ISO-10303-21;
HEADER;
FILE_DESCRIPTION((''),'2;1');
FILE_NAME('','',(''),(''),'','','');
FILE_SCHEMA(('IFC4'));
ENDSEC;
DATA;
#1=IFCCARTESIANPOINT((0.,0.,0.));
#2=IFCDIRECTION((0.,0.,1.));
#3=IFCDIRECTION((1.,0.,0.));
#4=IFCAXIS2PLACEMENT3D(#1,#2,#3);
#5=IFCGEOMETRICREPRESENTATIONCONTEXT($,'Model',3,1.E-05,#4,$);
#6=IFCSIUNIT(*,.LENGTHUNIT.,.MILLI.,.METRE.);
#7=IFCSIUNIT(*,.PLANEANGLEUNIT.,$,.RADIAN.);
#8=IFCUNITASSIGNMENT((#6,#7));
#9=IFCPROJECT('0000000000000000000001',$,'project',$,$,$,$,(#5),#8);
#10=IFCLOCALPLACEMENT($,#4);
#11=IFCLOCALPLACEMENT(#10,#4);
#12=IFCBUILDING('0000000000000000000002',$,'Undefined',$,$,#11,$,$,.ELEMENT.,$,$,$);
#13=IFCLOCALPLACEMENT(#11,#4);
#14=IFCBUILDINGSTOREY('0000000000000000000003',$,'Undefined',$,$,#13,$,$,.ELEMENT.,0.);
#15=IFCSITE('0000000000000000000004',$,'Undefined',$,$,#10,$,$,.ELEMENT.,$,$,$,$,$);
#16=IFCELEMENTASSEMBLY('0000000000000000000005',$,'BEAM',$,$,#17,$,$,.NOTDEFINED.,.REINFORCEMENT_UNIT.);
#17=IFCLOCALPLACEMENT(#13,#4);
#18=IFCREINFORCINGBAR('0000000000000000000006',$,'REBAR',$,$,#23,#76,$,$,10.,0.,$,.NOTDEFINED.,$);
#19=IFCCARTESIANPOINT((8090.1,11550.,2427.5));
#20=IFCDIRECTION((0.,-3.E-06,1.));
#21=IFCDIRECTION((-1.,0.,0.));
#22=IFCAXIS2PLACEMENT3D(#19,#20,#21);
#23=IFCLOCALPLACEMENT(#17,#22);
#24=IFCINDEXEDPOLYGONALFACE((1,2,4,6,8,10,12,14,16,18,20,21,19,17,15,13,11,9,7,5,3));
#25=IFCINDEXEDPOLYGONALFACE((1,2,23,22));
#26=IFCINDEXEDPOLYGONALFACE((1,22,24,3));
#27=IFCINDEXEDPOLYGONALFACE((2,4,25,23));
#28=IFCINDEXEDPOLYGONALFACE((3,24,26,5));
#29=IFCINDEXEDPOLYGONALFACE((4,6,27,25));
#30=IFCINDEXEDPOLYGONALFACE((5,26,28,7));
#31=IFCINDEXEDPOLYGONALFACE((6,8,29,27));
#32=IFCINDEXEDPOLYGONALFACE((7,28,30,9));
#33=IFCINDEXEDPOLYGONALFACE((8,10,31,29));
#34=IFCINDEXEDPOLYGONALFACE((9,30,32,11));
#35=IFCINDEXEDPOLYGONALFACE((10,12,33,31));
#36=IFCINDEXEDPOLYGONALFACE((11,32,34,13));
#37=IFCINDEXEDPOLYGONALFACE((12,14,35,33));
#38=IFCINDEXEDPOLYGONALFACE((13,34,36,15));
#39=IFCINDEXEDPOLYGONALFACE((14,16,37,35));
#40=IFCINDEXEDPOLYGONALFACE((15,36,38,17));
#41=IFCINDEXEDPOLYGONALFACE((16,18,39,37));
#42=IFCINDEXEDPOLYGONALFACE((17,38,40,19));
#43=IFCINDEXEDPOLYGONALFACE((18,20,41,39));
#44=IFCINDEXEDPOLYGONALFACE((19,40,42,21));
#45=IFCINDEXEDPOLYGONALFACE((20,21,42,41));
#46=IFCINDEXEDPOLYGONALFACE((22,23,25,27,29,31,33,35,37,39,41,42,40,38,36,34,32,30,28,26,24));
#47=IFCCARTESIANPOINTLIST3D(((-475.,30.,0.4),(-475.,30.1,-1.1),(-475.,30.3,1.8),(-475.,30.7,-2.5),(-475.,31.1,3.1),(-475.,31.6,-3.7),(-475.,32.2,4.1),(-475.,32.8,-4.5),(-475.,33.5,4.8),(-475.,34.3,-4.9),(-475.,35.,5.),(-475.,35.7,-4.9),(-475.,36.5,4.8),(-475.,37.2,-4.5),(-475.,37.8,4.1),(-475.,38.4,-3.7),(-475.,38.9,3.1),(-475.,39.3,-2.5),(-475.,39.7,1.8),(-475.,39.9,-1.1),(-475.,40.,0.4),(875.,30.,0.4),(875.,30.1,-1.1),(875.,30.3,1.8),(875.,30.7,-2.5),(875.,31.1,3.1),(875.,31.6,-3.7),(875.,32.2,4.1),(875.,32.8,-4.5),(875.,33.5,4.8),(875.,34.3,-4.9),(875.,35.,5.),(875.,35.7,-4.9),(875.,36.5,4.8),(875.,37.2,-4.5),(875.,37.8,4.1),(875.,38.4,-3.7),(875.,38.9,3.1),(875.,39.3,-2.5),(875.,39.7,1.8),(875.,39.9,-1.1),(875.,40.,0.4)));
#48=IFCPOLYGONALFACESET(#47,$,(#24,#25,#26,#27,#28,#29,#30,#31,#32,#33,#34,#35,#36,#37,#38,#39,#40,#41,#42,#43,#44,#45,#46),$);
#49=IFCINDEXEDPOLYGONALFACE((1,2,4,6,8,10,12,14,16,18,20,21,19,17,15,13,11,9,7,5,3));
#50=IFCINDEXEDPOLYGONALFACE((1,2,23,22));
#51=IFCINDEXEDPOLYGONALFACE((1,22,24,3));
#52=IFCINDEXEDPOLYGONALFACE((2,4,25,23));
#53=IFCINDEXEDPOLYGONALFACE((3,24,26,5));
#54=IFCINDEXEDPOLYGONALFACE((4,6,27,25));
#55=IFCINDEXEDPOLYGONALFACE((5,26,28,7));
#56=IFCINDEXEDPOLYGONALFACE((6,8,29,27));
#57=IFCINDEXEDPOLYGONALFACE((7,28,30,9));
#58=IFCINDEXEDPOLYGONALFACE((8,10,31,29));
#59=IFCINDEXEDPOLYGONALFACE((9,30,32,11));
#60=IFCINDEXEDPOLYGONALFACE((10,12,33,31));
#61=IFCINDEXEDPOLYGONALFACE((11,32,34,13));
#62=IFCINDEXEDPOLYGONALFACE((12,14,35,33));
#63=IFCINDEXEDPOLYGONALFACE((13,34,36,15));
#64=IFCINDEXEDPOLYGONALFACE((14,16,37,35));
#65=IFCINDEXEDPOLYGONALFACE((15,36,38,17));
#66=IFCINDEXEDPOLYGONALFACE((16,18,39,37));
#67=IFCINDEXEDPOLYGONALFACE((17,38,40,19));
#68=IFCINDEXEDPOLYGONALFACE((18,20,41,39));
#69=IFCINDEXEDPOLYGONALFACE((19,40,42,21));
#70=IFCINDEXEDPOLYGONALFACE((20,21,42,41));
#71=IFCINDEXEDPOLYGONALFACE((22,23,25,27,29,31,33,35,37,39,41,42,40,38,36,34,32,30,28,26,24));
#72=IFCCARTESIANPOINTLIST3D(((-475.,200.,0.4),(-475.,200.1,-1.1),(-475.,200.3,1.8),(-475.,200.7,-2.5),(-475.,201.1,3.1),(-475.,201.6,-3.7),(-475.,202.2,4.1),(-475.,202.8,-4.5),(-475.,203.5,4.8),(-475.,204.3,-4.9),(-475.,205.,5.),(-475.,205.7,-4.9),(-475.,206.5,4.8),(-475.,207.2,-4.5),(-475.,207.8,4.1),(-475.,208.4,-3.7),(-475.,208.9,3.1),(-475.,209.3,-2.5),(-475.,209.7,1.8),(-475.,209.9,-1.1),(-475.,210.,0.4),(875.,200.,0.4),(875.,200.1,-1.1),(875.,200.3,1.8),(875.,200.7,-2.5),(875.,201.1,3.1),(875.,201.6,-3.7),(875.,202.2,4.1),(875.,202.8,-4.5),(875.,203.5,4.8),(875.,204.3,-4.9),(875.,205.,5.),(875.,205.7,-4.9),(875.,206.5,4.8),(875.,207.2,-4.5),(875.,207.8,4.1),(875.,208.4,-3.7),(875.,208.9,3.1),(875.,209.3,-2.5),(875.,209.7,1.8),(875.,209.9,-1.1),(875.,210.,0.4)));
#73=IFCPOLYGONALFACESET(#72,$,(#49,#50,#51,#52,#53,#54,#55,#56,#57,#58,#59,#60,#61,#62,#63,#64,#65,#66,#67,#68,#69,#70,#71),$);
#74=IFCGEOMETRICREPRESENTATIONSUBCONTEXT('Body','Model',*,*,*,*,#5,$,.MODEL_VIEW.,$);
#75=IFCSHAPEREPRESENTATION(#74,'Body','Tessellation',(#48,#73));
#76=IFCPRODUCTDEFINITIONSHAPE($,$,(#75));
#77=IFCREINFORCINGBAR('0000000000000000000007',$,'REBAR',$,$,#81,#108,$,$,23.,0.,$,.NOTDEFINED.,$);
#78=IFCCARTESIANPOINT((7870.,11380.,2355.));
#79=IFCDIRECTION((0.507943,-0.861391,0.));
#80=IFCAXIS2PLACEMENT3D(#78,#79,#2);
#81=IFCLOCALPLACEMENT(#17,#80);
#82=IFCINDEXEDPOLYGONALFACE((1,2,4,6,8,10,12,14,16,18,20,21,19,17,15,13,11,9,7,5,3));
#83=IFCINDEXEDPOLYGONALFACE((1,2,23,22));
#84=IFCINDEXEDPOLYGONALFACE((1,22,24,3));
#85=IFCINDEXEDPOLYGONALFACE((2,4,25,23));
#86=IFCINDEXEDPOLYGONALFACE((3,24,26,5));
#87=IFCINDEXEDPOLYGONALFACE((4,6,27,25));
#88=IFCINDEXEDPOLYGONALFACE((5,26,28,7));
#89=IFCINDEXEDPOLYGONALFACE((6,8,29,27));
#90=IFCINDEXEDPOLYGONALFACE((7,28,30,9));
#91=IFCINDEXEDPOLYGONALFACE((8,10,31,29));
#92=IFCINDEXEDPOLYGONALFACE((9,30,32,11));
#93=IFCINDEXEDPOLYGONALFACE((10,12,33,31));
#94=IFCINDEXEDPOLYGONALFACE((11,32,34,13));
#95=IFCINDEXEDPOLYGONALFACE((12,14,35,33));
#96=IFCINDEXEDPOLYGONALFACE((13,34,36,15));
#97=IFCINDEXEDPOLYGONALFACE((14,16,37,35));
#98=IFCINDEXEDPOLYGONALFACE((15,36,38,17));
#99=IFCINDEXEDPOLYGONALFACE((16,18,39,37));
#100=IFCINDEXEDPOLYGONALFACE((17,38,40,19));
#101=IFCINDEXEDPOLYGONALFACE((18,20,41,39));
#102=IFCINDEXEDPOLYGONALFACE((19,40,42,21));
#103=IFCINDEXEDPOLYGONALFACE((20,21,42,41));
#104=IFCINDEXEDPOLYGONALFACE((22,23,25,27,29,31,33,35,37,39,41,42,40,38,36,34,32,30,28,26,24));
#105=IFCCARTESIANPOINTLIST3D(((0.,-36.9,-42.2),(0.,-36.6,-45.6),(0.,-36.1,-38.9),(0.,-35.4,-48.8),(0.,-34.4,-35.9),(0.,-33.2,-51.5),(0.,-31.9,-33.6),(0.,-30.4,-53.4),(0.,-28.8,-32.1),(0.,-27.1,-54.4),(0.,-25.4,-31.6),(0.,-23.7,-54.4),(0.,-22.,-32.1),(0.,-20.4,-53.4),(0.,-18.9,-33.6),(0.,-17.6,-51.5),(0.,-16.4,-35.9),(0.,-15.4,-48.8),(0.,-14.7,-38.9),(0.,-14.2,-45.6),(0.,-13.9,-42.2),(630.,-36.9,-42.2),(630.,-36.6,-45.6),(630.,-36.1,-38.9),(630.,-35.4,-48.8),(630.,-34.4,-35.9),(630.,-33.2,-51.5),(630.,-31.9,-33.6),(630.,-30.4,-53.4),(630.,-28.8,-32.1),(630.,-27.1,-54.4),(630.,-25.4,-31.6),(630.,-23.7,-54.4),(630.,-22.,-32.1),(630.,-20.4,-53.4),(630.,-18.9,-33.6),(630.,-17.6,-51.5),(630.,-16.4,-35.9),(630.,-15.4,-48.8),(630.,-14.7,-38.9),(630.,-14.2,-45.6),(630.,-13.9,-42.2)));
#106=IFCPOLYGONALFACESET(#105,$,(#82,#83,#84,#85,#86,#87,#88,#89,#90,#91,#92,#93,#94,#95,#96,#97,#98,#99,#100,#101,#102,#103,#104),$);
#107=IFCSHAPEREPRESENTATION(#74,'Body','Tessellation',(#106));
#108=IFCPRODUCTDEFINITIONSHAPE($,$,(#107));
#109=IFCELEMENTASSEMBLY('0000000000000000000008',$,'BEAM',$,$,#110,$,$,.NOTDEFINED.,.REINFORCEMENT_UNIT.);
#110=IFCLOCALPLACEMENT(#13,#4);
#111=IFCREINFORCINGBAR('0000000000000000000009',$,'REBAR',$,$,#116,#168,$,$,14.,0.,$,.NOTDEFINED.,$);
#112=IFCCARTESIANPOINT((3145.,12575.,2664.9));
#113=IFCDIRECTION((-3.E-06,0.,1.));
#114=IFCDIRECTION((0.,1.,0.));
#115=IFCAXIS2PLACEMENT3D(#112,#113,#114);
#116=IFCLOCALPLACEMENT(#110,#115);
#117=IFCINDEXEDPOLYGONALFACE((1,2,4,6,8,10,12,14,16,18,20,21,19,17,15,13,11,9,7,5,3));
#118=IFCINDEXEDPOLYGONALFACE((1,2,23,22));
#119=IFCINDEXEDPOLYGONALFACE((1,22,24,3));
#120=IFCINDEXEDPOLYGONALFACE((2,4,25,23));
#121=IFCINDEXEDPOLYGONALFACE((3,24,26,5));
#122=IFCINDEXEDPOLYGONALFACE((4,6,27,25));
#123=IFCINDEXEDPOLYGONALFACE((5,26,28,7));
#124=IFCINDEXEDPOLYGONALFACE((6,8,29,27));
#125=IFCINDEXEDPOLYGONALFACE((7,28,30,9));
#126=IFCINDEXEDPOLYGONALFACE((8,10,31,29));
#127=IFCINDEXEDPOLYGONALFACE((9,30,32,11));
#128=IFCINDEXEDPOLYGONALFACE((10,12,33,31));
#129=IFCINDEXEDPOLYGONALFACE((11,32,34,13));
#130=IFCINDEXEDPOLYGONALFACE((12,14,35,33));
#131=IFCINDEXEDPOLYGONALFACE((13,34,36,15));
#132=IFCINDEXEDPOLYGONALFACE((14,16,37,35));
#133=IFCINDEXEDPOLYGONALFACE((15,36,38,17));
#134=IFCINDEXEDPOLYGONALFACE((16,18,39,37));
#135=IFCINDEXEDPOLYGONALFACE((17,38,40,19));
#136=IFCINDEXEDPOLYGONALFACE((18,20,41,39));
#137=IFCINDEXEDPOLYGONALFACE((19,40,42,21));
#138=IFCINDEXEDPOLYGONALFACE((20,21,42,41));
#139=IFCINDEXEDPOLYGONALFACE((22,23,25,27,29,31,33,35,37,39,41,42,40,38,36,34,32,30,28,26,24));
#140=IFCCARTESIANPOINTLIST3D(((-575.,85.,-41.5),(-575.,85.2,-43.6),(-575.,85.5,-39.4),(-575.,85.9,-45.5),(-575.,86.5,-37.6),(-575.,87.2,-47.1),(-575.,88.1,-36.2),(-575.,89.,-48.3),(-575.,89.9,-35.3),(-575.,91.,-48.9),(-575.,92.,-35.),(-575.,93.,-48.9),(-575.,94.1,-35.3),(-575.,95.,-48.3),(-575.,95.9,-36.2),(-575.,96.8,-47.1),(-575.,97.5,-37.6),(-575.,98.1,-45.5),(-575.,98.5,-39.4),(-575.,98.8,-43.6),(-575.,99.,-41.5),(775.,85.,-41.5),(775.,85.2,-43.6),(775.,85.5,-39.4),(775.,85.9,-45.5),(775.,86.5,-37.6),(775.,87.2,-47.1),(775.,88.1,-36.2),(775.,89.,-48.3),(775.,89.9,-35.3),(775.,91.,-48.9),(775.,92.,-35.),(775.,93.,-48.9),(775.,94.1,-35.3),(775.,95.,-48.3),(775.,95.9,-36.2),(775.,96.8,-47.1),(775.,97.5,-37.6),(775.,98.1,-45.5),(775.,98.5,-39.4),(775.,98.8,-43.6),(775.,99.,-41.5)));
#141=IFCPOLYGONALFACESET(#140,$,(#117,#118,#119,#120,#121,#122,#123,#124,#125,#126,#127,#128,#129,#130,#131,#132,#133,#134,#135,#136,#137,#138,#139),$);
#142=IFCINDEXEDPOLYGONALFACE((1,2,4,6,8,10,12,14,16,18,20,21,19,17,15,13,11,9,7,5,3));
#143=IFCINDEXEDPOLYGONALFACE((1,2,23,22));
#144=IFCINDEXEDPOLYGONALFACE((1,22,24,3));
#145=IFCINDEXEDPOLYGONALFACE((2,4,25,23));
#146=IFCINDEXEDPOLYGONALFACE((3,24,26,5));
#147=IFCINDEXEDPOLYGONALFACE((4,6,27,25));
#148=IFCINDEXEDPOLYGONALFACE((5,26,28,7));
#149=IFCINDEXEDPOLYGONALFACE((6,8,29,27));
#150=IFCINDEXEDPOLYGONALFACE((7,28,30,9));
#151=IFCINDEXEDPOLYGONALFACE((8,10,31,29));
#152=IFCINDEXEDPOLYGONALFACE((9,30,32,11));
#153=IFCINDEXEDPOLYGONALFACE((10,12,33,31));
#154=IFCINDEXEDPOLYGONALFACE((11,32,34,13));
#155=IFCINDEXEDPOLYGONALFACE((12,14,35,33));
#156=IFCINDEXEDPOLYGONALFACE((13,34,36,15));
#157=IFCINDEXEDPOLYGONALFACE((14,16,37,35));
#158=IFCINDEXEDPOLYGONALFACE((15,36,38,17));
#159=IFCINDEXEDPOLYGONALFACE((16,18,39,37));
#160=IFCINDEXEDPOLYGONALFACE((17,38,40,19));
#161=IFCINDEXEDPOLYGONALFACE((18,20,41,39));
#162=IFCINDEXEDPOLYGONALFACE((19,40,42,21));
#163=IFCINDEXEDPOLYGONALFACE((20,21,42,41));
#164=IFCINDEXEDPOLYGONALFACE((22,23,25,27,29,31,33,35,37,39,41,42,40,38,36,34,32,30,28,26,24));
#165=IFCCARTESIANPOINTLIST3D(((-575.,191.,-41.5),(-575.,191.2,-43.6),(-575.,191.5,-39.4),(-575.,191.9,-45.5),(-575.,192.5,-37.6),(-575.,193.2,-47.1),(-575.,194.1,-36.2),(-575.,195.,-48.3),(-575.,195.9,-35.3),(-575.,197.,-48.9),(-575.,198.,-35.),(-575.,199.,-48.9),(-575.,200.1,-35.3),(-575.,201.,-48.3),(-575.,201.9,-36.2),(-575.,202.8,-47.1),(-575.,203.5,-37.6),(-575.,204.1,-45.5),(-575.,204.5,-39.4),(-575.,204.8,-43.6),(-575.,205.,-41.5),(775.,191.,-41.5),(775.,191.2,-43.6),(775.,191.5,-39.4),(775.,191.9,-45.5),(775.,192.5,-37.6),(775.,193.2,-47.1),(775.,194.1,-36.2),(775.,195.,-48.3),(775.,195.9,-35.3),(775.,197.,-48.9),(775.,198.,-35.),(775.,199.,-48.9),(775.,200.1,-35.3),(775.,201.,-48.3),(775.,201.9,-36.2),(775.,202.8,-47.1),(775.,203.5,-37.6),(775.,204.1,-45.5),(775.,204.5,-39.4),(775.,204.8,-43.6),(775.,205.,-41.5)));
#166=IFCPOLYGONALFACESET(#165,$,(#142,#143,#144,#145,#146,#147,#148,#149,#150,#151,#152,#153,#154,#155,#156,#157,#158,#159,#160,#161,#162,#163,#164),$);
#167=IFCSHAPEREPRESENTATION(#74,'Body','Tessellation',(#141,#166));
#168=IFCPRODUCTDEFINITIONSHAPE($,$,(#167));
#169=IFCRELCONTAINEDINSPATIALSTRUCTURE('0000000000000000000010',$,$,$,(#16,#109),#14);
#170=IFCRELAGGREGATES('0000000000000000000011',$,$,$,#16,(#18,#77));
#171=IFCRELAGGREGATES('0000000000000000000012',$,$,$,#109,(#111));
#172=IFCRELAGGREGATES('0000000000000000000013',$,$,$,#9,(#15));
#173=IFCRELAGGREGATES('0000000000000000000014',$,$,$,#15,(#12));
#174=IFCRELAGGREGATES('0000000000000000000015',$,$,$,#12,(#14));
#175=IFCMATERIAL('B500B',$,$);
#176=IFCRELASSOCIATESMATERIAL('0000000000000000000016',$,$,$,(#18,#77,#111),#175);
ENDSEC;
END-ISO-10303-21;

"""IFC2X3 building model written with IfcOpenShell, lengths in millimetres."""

from ifc_helpers import new_model, entity, si_unit, frame, origin_with_axes, place, context, subcontext, project, spatial, source, transform, mapped, material, element, aggregate, save


model = new_model("IFC2X3")

# Units and contexts
model_context = context("Model", 3, precision=1e-05, world=origin_with_axes())
body_context = subcontext(model_context, "Body", "Model", "MODEL_VIEW")
ifc_project = project(units=[si_unit("LENGTHUNIT", "METRE", prefix="MILLI"), si_unit("PLANEANGLEUNIT", "RADIAN")], contexts=[model_context])

# Site, building, storey
site_placement = place(None, origin_with_axes())
site = spatial("IfcSite", under=ifc_project, at=site_placement, Name="Undefined", CompositionType="ELEMENT")
building_placement = place(site_placement, origin_with_axes())
building = spatial("IfcBuilding", under=site, at=building_placement, Name="Undefined", CompositionType="ELEMENT")
storey_placement = place(building_placement, origin_with_axes())
storey = spatial("IfcBuildingStorey", under=building, at=storey_placement, Name="Undefined", CompositionType="ELEMENT", Elevation=0.0)

# Element assembly
assembly_1_placement = place(storey_placement, origin_with_axes())
assembly_1 = element("IfcElementAssembly", 1, at=assembly_1_placement, inside=storey, Name="BEAM", AssemblyPlace="NOTDEFINED", PredefinedType="REINFORCEMENT_UNIT")

# Shared definitions
ifc_material_1 = material(Name="B500B")

# Reinforcing bars
shared_shape_1 = source(origin_with_axes(), body_context, "Body", "AdvancedSweptSolid", [
    entity("IfcSweptDiskSolid", entity("IfcTrimmedCurve", entity("IfcLine", entity("IfcCartesianPoint", [0.0, 0.0, 0.0]), entity("IfcVector", entity("IfcDirection", [1.0, 0.0, 0.0]), 1.0)), [entity("IfcParameterValue", 0.0)], [entity("IfcParameterValue", 1349.999613)], True, "PARAMETER"), 5.0, None, 0.0, 1350.0),
])
shared_shape_2 = source(origin_with_axes(), body_context, "Body", "AdvancedSweptSolid", [
    entity("IfcSweptDiskSolid", entity("IfcTrimmedCurve", entity("IfcLine", entity("IfcCartesianPoint", [0.0, 0.0, 0.0]), entity("IfcVector", entity("IfcDirection", [1.0, 0.0, 0.0]), 1.0)), [entity("IfcParameterValue", 0.0)], [entity("IfcParameterValue", 1349.999613)], True, "PARAMETER"), 5.0, None, 0.0, 1350.0),
])
reinforcing_bar_1_placement = place(assembly_1_placement, frame((8090.1, 11550.0, 2427.5), z_axis=(0.0, -0.000003, 1.0), x_axis=(-1.0, 0.0, 0.0)))
reinforcing_bar_1 = element("IfcReinforcingBar", 2, at=reinforcing_bar_1_placement, material=ifc_material_1, Name="REBAR", BarRole="NOTDEFINED", CrossSectionArea=0.0, NominalDiameter=10.0, context=body_context, shape_type="MappedRepresentation", body=[
    mapped(shared_shape_1, transform((-475.0, 35.0, 0.0))),
    mapped(shared_shape_2, transform((-475.0, 205.0, 0.0))),
])
shared_shape_3 = source(origin_with_axes(), body_context, "Body", "AdvancedSweptSolid", [
    entity("IfcSweptDiskSolid", entity("IfcTrimmedCurve", entity("IfcLine", entity("IfcCartesianPoint", [0.0, 0.0, 0.0]), entity("IfcVector", entity("IfcDirection", [1.0, 0.0, 0.0]), 1.0)), [entity("IfcParameterValue", 0.0)], [entity("IfcParameterValue", 630.0)], True, "PARAMETER"), 11.5, None, 0.0, 630.0),
])
reinforcing_bar_2_placement = place(assembly_1_placement, frame((7870.0, 11380.0, 2355.0), z_axis=(0.507943, -0.861391, 0.0), x_axis=(0.0, 0.0, 1.0)))
reinforcing_bar_2 = element("IfcReinforcingBar", 3, at=reinforcing_bar_2_placement, material=ifc_material_1, Name="REBAR", BarRole="NOTDEFINED", CrossSectionArea=0.0, NominalDiameter=23.0, context=body_context, shape_type="MappedRepresentation", body=[
    mapped(shared_shape_3, transform((0.0, -25.4, -43.1))),
])
aggregate(assembly_1, [reinforcing_bar_1, reinforcing_bar_2])

# Element assembly, reinforcing bar
assembly_2_placement = place(storey_placement, origin_with_axes())
assembly_2 = element("IfcElementAssembly", 4, at=assembly_2_placement, inside=storey, Name="BEAM", AssemblyPlace="NOTDEFINED", PredefinedType="REINFORCEMENT_UNIT")
shared_shape_4 = source(origin_with_axes(), body_context, "Body", "AdvancedSweptSolid", [
    entity("IfcSweptDiskSolid", entity("IfcTrimmedCurve", entity("IfcLine", entity("IfcCartesianPoint", [0.0, 0.0, 0.0]), entity("IfcVector", entity("IfcDirection", [1.0, 0.0, 0.0]), 1.0)), [entity("IfcParameterValue", 0.0)], [entity("IfcParameterValue", 1349.999613)], True, "PARAMETER"), 7.0, None, 0.0, 1350.0),
])
shared_shape_5 = source(origin_with_axes(), body_context, "Body", "AdvancedSweptSolid", [
    entity("IfcSweptDiskSolid", entity("IfcTrimmedCurve", entity("IfcLine", entity("IfcCartesianPoint", [0.0, 0.0, 0.0]), entity("IfcVector", entity("IfcDirection", [1.0, 0.0, 0.0]), 1.0)), [entity("IfcParameterValue", 0.0)], [entity("IfcParameterValue", 1349.999613)], True, "PARAMETER"), 7.0, None, 0.0, 1350.0),
])
reinforcing_bar_3_placement = place(assembly_2_placement, frame((3145.0, 12575.0, 2664.9), z_axis=(-0.000003, 0.0, 1.0), x_axis=(0.0, 1.0, 0.0)))
reinforcing_bar_3 = element("IfcReinforcingBar", 5, at=reinforcing_bar_3_placement, material=ifc_material_1, Name="REBAR", BarRole="NOTDEFINED", CrossSectionArea=0.0, NominalDiameter=14.0, context=body_context, shape_type="MappedRepresentation", body=[
    mapped(shared_shape_4, transform((-575.0, 92.0, -42.0))),
    mapped(shared_shape_5, transform((-575.0, 198.0, -42.0))),
])
aggregate(assembly_2, [reinforcing_bar_3])

save(model, "model.ifc")
